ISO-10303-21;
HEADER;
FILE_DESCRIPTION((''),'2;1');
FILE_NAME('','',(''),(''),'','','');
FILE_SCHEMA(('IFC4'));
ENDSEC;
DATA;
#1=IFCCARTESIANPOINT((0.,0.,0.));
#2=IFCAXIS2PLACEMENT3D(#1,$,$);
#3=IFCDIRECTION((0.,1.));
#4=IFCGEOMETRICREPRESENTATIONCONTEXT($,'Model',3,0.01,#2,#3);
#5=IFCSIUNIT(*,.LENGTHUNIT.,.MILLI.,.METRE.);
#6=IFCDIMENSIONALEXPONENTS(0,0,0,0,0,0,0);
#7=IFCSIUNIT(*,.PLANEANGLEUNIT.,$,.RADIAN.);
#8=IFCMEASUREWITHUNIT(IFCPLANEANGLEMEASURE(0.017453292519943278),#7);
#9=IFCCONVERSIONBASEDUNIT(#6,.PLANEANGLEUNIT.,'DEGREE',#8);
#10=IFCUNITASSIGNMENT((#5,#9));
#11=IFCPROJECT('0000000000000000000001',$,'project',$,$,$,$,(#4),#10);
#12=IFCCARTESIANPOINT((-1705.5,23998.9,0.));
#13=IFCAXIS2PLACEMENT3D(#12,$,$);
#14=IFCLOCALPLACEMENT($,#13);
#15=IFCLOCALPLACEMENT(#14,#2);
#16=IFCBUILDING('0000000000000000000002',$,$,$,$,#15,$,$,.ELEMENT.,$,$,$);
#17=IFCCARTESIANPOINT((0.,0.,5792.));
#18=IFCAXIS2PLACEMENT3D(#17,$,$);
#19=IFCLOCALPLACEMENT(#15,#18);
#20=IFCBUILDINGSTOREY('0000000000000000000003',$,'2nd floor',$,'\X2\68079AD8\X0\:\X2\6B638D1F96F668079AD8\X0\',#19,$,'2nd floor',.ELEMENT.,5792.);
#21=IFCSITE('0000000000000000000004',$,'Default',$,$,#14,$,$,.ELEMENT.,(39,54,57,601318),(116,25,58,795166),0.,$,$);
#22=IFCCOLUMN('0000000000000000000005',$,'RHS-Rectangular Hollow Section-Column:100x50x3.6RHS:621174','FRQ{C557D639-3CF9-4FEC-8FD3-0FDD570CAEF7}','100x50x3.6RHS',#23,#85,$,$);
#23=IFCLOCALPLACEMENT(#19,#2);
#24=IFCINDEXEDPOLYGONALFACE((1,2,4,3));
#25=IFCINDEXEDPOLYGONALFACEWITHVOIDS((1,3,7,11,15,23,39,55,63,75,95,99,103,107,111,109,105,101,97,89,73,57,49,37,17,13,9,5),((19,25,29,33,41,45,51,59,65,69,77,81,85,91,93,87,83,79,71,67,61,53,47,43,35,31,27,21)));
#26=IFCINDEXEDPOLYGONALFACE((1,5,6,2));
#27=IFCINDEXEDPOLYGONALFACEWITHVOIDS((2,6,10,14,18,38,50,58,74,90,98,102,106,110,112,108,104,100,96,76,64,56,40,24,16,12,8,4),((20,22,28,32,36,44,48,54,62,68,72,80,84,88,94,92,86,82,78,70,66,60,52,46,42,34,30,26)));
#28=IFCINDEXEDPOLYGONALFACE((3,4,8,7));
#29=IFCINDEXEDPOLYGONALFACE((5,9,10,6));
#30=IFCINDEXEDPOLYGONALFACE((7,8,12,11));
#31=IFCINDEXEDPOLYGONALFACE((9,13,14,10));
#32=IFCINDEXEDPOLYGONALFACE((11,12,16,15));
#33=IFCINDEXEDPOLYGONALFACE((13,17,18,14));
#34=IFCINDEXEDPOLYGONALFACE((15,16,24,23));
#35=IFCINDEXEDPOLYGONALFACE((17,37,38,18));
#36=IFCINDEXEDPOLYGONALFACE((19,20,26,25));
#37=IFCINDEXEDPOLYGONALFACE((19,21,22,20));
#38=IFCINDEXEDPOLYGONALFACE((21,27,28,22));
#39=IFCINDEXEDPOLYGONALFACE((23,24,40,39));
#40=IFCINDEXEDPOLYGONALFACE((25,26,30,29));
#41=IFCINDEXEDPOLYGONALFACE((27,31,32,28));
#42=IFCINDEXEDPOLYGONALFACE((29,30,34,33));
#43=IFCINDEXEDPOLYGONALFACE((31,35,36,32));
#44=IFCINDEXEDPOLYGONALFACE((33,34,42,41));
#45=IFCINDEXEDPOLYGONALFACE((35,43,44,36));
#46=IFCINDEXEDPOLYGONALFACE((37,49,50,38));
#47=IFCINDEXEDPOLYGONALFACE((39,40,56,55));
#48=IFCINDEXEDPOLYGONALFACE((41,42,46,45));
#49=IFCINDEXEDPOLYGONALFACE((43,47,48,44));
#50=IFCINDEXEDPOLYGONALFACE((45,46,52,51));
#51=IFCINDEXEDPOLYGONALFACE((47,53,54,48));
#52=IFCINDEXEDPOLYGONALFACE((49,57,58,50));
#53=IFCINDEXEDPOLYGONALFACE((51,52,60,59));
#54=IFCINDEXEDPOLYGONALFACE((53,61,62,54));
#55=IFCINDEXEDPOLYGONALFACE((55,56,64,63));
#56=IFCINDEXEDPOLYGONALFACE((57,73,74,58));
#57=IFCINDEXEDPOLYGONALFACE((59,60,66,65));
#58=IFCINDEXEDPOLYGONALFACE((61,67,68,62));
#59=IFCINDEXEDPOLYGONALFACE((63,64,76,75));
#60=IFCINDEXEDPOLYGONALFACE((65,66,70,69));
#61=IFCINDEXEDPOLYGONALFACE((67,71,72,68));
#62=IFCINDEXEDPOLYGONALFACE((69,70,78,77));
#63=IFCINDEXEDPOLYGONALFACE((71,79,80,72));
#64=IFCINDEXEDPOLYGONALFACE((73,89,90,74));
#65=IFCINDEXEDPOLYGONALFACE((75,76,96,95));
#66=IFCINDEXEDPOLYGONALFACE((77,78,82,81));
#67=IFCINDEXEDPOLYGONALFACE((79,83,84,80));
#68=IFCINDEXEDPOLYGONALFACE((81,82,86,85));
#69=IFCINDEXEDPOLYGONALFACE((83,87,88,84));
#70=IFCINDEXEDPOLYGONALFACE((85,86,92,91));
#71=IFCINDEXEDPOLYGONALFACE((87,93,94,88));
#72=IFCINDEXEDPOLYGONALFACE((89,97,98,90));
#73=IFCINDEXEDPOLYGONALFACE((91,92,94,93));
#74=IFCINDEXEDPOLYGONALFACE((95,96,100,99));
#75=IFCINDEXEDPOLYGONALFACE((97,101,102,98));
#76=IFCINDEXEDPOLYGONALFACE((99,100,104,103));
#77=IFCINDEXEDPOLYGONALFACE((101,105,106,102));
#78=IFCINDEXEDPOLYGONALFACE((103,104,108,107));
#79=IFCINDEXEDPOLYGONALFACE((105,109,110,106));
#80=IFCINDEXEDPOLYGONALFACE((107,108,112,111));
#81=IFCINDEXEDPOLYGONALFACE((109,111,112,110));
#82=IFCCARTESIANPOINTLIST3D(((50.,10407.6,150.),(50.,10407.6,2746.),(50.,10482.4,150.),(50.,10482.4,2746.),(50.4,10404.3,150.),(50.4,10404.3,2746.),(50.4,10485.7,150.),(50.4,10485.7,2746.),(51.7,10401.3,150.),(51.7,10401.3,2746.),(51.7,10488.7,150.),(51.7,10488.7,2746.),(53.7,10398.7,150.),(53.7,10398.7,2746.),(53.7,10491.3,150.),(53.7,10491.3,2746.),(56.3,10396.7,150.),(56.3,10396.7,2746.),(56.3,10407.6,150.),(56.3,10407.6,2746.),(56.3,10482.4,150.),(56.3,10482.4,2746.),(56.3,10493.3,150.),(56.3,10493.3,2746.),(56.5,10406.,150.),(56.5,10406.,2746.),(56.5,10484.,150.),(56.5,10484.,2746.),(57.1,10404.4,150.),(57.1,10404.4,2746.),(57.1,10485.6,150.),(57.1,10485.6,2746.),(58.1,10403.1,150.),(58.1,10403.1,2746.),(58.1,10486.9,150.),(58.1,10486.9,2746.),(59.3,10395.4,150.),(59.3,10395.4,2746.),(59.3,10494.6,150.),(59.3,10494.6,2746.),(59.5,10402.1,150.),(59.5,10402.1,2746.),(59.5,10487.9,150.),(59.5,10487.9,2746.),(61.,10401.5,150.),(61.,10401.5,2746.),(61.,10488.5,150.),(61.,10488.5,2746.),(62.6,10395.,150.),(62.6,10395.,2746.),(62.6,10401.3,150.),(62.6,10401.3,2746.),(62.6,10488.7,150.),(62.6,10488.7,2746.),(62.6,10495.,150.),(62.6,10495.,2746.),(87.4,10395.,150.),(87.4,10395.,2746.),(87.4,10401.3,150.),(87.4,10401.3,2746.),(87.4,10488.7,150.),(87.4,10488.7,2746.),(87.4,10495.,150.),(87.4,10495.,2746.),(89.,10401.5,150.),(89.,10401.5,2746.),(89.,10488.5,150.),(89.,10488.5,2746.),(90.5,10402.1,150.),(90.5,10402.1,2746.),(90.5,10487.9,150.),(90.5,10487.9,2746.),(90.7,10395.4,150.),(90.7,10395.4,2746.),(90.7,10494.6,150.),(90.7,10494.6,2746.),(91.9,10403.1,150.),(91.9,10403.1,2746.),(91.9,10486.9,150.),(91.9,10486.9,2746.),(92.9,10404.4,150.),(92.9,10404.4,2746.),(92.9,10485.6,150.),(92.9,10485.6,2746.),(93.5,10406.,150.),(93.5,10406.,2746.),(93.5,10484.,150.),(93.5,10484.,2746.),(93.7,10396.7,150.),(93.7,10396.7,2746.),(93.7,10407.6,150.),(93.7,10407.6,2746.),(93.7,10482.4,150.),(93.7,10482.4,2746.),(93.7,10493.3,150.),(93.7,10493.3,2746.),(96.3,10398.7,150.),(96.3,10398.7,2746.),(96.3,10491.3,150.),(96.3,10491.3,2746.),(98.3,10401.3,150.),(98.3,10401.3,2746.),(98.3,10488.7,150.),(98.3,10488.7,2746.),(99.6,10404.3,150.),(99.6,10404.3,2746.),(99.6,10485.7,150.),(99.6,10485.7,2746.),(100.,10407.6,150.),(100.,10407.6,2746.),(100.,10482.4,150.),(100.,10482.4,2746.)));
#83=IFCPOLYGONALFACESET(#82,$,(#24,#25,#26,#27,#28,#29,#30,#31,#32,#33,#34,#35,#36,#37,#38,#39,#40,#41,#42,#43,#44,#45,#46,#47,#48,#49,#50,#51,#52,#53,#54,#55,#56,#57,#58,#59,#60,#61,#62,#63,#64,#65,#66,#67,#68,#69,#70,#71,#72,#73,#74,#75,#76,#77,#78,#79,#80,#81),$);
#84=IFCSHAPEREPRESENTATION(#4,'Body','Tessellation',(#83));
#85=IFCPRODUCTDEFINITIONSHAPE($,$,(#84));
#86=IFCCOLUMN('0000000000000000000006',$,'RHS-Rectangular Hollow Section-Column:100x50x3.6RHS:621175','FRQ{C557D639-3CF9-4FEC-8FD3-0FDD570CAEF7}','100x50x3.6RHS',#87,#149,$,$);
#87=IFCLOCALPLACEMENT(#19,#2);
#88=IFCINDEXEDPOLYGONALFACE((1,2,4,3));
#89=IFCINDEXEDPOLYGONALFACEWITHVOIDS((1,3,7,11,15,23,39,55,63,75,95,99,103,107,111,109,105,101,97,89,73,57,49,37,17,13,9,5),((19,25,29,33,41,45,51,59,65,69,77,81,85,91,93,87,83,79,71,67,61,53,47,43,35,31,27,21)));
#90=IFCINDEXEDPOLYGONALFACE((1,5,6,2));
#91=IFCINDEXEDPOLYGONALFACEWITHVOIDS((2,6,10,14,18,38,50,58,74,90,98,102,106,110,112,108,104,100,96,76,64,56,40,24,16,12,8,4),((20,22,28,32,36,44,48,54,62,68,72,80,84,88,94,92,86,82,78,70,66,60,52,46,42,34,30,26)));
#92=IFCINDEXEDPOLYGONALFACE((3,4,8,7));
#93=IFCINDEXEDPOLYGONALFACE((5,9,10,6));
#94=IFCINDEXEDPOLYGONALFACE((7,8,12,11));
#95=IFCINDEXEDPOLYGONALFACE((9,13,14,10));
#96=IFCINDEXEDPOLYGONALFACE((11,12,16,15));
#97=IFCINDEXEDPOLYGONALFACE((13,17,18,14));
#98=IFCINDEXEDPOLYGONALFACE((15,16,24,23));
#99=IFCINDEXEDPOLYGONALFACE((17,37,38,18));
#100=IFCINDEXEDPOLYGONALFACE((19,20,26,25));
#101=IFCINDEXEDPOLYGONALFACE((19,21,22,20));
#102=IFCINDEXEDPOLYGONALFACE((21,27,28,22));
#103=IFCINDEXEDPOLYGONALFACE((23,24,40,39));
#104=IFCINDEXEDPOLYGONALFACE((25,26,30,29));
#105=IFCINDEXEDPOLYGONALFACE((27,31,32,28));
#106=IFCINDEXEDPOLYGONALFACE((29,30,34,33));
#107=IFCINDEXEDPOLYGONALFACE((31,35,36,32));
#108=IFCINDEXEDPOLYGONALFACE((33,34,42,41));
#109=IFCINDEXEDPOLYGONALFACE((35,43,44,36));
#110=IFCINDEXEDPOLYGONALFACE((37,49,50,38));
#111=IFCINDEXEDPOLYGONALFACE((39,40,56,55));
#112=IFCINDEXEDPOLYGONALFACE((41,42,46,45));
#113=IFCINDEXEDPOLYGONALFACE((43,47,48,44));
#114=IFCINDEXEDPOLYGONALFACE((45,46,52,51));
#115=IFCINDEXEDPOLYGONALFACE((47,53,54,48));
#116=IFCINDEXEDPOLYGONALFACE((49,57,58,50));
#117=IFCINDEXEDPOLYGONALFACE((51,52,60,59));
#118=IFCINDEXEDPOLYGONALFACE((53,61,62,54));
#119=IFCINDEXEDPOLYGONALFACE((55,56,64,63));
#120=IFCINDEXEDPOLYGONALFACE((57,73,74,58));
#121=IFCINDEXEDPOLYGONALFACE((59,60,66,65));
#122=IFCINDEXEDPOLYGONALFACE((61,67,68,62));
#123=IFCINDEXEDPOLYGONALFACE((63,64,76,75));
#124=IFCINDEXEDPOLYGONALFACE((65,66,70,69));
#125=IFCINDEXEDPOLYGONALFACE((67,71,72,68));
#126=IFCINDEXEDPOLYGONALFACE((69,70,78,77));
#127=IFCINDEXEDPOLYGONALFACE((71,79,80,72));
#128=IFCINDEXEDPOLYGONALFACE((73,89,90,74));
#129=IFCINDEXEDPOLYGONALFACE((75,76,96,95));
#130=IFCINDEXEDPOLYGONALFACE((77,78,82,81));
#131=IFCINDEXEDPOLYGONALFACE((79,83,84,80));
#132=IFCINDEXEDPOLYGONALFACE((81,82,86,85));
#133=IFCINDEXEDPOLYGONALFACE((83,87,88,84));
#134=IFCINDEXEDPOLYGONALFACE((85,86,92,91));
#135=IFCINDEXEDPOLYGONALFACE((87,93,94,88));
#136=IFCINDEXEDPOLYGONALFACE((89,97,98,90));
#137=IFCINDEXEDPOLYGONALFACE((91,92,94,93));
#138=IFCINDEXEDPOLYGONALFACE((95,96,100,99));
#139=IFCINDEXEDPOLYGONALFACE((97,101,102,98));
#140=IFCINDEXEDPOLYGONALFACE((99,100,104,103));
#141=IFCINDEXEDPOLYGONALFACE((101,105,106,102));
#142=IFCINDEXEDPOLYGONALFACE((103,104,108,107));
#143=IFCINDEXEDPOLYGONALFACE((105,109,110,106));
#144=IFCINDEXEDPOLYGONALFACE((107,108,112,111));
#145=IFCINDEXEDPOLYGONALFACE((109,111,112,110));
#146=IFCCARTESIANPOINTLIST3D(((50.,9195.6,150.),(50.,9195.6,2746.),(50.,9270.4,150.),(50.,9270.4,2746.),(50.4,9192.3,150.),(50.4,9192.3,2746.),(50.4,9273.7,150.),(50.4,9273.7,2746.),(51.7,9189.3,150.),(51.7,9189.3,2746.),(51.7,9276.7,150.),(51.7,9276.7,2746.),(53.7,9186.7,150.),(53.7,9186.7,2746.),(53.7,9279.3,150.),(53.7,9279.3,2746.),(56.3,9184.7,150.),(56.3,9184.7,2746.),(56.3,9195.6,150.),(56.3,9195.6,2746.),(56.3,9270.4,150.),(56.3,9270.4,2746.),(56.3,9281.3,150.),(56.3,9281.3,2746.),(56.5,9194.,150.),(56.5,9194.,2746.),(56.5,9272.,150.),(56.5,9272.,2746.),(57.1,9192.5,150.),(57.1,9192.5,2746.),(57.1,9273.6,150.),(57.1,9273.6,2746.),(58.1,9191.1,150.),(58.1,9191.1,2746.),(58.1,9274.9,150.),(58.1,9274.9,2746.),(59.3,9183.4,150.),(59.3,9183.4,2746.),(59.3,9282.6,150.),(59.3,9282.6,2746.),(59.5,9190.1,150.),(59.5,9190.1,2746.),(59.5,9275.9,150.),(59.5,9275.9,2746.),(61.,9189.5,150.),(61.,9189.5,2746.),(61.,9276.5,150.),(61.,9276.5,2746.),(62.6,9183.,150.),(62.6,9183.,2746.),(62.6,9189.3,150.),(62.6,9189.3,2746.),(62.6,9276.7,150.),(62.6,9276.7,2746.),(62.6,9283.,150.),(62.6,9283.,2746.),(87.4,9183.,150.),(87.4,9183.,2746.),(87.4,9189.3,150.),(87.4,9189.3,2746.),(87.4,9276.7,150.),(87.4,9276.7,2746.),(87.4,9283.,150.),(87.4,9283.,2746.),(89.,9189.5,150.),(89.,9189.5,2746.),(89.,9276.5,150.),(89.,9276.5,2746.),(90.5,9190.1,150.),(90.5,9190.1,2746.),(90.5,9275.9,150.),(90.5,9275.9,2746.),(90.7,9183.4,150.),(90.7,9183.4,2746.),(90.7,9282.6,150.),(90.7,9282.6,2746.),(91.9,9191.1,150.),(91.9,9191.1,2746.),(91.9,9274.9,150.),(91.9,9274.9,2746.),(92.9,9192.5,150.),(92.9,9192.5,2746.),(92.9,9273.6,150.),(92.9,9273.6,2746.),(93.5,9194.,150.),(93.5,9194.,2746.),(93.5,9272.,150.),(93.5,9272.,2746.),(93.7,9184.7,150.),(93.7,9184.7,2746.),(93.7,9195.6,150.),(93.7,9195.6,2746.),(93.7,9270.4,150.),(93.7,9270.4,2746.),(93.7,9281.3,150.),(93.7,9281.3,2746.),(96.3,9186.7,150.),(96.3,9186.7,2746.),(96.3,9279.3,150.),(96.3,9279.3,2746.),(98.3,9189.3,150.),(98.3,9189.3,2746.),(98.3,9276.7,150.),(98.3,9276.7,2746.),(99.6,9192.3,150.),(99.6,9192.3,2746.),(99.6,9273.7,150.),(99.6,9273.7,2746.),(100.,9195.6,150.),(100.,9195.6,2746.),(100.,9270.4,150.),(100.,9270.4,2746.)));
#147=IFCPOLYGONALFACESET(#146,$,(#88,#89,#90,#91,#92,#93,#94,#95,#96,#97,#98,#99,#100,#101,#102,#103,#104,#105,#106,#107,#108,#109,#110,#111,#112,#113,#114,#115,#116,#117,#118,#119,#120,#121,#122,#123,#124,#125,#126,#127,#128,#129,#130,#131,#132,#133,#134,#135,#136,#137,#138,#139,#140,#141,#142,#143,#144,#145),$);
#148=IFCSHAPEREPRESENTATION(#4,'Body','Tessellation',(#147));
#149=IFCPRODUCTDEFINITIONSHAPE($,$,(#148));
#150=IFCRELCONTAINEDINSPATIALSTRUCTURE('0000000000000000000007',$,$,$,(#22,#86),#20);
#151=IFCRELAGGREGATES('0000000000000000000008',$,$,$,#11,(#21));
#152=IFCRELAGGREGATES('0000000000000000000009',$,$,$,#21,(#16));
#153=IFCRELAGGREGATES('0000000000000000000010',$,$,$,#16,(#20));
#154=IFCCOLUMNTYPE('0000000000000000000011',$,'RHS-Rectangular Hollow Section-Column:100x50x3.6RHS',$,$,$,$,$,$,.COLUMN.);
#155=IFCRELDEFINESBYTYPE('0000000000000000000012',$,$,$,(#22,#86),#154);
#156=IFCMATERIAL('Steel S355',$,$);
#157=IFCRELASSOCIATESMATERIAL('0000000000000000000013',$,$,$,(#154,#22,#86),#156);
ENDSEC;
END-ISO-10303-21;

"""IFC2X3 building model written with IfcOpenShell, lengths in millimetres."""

from ifc_helpers import new_model, entity, si_unit, converted_unit, direction, frame, origin, origin_2d, place, context, project, spatial, hollow_rectangle, extrude, clip, halfspace, material, type_object, element, save


model = new_model("IFC2X3")

# Units and contexts
model_context = context("Model", 3, precision=0.01, world=origin(), true_north=direction((0.0, 1.0)))
ifc_project = project(units=[si_unit("LENGTHUNIT", "METRE", prefix="MILLI"), converted_unit("PLANEANGLEUNIT", "DEGREE", entity("IfcPlaneAngleMeasure", 0.017453292519943278), si_unit("PLANEANGLEUNIT", "RADIAN"), dimensions=[0, 0, 0, 0, 0, 0, 0])], contexts=[model_context])

# Site, building, storey
site_placement = place(None, frame((-1705.5, 23998.9, 0.0)))
site = spatial("IfcSite", under=ifc_project, at=site_placement, Name="Default", CompositionType="ELEMENT", RefLatitude=(39, 54, 57, 601318), RefLongitude=(116, 25, 58, 795166), RefElevation=0.0)
building_placement = place(site_placement, origin())
building = spatial("IfcBuilding", under=site, at=building_placement, CompositionType="ELEMENT")
storey_placement = place(building_placement, frame((0.0, 0.0, 5792.0)))
storey = spatial("IfcBuildingStorey", under=building, at=storey_placement, Name="2nd floor", ObjectType="标高:正负零标高", LongName="2nd floor", CompositionType="ELEMENT", Elevation=5792.0)

# Columns
ifc_material_1 = material(Name="Steel S355")
column_type = type_object("IfcColumnType", Name="RHS-Rectangular Hollow Section-Column:100x50x3.6RHS", PredefinedType="COLUMN", material=ifc_material_1)
column_1_placement = place(storey_placement, frame((75.0, 10445.0, 2746.0), z_axis=(0.0, 0.0, 1.0), x_axis=(-1.0, 0.0, 0.0)))
element("IfcColumn", 1, at=column_1_placement, inside=storey, type_object=column_type, material=ifc_material_1, Name="RHS-Rectangular Hollow Section-Column:100x50x3.6RHS:621174", Description="FRQ{C557D639-3CF9-4FEC-8FD3-0FDD570CAEF7}", ObjectType="100x50x3.6RHS", context=model_context, shape_type="Clipping", body=[
    clip(extrude(hollow_rectangle(XDim=50.0, YDim=100.0, WallThickness=6.3, InnerFilletRadius=6.3, OuterFilletRadius=12.6, at=origin_2d()), origin(), (0.0, 0.0, -1.0), 2651.9), halfspace(frame((75.0, 10445.0, -2596.0), z_axis=(0.0, 0.0, 1.0), x_axis=(-1.0, 0.0, 0.0)), True)),
])
column_2_placement = place(storey_placement, frame((75.0, 9233.0, 2746.0), z_axis=(0.0, 0.0, 1.0), x_axis=(-1.0, 0.0, 0.0)))
element("IfcColumn", 2, at=column_2_placement, inside=storey, type_object=column_type, material=ifc_material_1, Name="RHS-Rectangular Hollow Section-Column:100x50x3.6RHS:621175", Description="FRQ{C557D639-3CF9-4FEC-8FD3-0FDD570CAEF7}", ObjectType="100x50x3.6RHS", context=model_context, shape_type="Clipping", body=[
    clip(extrude(hollow_rectangle(XDim=50.0, YDim=100.0, WallThickness=6.3, InnerFilletRadius=6.3, OuterFilletRadius=12.6, at=origin_2d()), origin(), (0.0, 0.0, -1.0), 2651.9), halfspace(frame((75.0, 9233.0, -2596.0), z_axis=(0.0, 0.0, 1.0), x_axis=(-1.0, 0.0, 0.0)), True)),
])

save(model, "model.ifc")
